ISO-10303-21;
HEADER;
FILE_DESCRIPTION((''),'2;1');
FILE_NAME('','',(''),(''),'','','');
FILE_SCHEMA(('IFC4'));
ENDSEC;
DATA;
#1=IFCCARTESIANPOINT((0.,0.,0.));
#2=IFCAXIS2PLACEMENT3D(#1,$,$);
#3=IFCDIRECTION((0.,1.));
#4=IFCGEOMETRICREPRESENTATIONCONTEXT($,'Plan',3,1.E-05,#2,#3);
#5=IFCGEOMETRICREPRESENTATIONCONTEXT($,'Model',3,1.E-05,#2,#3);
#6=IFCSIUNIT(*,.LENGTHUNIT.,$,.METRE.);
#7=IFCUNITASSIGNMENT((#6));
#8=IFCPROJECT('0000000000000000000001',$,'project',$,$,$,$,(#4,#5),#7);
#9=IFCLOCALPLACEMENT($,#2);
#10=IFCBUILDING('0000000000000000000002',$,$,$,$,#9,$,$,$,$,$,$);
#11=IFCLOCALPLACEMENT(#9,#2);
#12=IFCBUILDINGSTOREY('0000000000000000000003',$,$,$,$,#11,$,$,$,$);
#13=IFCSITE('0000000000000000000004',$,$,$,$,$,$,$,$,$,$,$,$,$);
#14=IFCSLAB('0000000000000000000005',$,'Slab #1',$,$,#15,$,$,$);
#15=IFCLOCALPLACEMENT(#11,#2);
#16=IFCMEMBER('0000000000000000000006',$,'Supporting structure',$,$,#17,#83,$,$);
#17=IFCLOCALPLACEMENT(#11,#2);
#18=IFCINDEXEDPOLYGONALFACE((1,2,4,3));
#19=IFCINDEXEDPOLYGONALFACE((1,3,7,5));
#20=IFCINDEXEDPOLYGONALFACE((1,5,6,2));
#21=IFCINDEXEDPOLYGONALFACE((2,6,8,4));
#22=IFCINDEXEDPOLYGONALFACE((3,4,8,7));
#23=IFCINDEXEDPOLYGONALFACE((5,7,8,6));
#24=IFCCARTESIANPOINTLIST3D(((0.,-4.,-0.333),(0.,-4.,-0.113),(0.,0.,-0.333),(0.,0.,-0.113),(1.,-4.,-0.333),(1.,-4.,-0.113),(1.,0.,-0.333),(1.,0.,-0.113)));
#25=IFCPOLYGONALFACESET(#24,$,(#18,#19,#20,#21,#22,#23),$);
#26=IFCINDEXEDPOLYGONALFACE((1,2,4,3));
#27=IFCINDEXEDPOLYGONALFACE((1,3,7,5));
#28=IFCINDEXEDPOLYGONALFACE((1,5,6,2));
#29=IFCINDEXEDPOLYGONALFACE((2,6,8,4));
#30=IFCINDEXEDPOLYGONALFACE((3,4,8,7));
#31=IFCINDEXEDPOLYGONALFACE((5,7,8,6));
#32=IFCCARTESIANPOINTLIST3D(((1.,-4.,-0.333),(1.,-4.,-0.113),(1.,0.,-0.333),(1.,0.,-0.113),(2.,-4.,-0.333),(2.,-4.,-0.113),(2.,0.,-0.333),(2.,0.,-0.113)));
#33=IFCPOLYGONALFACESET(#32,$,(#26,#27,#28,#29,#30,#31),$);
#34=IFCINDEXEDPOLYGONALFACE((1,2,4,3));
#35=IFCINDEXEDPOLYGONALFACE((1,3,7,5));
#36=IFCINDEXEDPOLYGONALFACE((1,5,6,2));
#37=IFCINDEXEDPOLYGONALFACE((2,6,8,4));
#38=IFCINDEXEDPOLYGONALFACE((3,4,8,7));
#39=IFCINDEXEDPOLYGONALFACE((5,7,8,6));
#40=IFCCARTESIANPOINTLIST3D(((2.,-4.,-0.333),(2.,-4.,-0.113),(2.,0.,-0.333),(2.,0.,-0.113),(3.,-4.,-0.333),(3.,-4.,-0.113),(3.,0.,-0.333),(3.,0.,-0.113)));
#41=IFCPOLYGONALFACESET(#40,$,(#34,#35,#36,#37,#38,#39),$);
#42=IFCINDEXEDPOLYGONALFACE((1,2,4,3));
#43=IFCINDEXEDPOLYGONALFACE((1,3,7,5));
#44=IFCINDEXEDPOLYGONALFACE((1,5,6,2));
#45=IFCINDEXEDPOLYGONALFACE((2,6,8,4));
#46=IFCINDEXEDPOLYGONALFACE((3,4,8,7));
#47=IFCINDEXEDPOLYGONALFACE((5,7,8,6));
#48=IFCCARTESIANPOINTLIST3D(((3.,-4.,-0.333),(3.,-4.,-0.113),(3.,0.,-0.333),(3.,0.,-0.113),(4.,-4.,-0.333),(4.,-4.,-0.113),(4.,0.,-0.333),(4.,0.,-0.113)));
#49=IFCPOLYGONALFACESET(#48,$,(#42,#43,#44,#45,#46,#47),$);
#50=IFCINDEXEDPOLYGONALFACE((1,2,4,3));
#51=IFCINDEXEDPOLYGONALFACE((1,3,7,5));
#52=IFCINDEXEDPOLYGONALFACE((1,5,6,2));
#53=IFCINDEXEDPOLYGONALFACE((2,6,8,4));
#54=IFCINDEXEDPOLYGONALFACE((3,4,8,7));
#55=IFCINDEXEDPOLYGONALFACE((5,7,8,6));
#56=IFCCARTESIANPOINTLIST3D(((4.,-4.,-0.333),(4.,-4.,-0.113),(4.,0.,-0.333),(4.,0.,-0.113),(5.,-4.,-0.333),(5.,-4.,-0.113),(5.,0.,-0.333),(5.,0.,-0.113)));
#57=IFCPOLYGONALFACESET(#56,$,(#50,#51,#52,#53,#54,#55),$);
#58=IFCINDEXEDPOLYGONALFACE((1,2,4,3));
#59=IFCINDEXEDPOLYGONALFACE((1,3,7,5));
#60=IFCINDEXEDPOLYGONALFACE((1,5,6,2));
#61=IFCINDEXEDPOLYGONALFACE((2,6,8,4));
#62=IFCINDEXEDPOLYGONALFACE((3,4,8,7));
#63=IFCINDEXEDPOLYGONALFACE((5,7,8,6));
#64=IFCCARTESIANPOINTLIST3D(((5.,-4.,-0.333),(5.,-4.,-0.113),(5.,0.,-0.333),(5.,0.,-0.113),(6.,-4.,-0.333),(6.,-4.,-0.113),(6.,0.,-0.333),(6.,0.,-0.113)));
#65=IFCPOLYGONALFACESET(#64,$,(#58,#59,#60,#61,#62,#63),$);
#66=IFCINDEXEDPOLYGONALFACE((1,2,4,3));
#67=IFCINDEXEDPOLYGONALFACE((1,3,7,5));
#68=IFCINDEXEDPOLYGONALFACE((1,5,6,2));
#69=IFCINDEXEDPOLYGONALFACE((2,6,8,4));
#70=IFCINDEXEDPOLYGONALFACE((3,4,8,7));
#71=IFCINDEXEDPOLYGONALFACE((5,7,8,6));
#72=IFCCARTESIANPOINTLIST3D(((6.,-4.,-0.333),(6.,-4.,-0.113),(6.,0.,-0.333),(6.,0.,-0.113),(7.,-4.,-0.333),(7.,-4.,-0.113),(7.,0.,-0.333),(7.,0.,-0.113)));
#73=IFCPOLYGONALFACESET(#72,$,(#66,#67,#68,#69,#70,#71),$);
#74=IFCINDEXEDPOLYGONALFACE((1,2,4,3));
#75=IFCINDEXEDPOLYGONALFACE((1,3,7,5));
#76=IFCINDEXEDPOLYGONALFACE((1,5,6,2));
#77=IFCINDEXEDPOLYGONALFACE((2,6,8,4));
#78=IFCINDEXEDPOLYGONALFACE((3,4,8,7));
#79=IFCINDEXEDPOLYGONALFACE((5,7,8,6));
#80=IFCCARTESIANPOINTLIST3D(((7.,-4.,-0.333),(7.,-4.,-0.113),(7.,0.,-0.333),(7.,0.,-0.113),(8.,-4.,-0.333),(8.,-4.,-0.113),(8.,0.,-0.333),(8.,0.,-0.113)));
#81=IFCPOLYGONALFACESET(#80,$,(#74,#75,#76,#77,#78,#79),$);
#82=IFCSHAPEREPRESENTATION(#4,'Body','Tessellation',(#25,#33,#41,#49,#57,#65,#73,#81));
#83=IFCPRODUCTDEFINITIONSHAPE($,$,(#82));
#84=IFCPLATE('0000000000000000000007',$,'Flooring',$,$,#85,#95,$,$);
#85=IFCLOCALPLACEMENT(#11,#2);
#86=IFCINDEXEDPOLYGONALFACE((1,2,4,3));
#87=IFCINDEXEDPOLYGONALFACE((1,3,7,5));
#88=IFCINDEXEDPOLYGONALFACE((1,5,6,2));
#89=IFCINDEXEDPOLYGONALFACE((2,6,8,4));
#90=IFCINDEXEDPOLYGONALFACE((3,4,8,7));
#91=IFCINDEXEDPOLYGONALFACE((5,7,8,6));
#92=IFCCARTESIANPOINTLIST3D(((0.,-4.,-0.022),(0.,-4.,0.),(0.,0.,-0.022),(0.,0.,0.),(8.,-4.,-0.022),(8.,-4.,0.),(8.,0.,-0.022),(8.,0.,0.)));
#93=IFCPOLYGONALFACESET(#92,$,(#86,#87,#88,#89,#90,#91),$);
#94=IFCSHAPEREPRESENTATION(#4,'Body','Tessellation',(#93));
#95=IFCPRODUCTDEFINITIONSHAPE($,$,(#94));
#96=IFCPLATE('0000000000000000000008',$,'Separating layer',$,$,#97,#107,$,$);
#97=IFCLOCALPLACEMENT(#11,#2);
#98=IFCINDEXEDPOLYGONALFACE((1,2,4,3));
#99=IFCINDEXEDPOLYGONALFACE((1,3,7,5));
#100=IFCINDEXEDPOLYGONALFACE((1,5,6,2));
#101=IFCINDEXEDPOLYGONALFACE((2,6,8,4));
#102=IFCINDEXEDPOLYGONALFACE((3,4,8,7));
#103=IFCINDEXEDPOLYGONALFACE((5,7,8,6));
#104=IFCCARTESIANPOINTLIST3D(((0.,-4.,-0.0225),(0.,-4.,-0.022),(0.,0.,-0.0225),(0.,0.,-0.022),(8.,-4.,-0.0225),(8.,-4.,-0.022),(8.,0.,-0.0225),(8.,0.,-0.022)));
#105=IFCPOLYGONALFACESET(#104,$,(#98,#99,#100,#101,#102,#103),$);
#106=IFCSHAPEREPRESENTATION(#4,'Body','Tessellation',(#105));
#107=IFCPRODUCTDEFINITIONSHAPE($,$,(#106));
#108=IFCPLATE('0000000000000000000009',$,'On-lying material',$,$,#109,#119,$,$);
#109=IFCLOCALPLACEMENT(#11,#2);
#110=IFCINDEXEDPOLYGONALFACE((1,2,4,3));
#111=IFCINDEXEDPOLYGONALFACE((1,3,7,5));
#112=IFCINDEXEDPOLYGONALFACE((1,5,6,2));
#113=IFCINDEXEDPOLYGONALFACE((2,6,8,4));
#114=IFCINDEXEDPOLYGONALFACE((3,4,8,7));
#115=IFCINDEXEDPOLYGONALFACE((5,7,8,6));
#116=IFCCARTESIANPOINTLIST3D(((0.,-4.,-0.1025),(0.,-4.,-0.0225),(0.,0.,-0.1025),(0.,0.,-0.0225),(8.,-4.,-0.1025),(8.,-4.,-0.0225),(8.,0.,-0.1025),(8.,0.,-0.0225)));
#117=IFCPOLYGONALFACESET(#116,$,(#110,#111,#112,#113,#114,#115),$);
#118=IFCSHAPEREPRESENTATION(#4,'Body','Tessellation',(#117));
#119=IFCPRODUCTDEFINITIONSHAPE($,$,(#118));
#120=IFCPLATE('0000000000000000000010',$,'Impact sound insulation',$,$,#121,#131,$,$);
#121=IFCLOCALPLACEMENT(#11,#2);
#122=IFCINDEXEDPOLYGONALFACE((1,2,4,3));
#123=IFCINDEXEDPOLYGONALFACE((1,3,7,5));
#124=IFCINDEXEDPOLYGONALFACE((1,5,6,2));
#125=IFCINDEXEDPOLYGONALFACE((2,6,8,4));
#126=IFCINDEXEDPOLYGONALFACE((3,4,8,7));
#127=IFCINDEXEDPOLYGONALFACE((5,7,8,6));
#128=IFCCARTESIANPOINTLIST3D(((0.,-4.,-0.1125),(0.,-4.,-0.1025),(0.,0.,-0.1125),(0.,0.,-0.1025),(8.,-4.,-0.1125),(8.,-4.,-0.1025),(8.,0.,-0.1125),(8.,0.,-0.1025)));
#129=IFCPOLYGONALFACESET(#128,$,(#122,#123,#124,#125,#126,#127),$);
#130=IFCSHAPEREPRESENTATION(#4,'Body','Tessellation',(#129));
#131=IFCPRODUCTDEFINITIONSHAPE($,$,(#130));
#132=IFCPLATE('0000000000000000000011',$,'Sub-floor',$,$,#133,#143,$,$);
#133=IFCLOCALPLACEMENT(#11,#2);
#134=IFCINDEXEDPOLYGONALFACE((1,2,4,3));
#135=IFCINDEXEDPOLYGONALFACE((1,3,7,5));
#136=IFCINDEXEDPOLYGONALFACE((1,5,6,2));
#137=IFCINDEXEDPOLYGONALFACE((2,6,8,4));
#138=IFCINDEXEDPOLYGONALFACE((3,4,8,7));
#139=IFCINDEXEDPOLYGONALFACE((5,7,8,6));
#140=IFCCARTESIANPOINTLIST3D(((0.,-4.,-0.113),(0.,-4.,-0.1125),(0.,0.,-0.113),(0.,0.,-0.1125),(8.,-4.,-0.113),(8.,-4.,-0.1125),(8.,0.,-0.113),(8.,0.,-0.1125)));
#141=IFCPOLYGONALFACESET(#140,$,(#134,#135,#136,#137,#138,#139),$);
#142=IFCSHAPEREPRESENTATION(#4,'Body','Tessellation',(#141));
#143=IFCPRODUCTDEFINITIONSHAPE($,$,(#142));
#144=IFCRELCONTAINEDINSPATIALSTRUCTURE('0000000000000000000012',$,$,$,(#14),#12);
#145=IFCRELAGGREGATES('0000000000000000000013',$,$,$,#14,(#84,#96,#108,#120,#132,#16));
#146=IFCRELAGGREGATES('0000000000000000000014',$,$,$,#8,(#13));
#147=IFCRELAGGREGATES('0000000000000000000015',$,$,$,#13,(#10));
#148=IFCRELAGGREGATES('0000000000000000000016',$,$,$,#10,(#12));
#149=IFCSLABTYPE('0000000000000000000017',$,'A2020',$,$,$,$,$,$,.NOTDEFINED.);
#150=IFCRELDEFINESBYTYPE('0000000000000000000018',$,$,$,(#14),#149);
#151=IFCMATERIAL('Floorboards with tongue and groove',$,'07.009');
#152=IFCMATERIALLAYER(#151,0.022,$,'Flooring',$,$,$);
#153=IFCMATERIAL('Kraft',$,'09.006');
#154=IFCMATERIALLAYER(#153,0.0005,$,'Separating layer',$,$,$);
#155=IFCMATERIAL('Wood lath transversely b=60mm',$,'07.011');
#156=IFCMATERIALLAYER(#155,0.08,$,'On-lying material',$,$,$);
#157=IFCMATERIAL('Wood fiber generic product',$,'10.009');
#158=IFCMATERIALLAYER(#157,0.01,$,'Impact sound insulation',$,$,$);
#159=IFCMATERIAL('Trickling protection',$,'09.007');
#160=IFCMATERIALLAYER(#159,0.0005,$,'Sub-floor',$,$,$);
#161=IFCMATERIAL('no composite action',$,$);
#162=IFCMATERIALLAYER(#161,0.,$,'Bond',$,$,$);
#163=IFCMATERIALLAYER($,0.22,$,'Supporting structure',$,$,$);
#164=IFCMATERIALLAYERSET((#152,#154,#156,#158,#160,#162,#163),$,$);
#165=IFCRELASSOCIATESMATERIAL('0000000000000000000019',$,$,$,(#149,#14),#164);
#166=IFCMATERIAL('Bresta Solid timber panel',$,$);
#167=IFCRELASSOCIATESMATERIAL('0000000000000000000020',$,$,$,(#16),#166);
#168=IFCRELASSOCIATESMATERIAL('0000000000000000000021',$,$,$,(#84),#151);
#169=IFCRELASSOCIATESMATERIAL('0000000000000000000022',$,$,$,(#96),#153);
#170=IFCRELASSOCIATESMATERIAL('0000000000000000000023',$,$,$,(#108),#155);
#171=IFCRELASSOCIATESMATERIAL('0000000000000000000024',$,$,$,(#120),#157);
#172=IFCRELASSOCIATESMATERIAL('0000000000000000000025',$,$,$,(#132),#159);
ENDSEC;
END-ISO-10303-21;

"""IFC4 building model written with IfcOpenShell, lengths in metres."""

from ifc_helpers import new_model, si_unit, direction, frame, frame_2d, origin, origin_with_axes, place, context, project, spatial, rectangle, extrude, material, layer, layer_set, type_object, element, aggregate, save


model = new_model("IFC4")

# Units and contexts
plan_context = context("Plan", 3, precision=1e-05, world=origin(), true_north=direction((0.0, 1.0)))
model_context = context("Model", 3, precision=1e-05, world=origin(), true_north=direction((0.0, 1.0)))
ifc_project = project(units=[si_unit("LENGTHUNIT", "METRE")], contexts=[plan_context, model_context])

# Site, building, storey
site = spatial("IfcSite", under=ifc_project)
building_placement = place(None, origin())
building = spatial("IfcBuilding", under=site, at=building_placement)
storey_placement = place(building_placement, origin())
storey = spatial("IfcBuildingStorey", under=building, at=storey_placement)

# Slab, member, plates
ifc_material_1 = material(Name="Floorboards with tongue and groove", Category="07.009")
ifc_layer_1 = layer(ifc_material_1, 0.022, Name="Flooring")
ifc_material_2 = material(Name="Kraft", Category="09.006")
ifc_layer_2 = layer(ifc_material_2, 0.0005, Name="Separating layer")
ifc_material_3 = material(Name="Wood lath transversely b=60mm", Category="07.011")
ifc_layer_3 = layer(ifc_material_3, 0.08, Name="On-lying material")
ifc_material_4 = material(Name="Wood fiber generic product", Category="10.009")
ifc_layer_4 = layer(ifc_material_4, 0.01, Name="Impact sound insulation")
ifc_material_5 = material(Name="Trickling protection", Category="09.007")
ifc_layer_5 = layer(ifc_material_5, 0.0005, Name="Sub-floor")
ifc_material_6 = material(Name="no composite action")
ifc_layer_6 = layer(ifc_material_6, 0.0, Name="Bond")
ifc_layer_7 = layer(None, 0.22, Name="Supporting structure")
ifc_layer_set = layer_set([ifc_layer_1, ifc_layer_2, ifc_layer_3, ifc_layer_4, ifc_layer_5, ifc_layer_6, ifc_layer_7])
slab_type = type_object("IfcSlabType", Name="A2020", PredefinedType="NOTDEFINED", material=ifc_layer_set)
slab_placement = place(None, frame((0.0, 0.0, 0.0), z_axis=(0.0, 0.0, -1.0), x_axis=(1.0, 0.0, 0.0)))
slab = element("IfcSlab", 1, at=slab_placement, inside=storey, type_object=slab_type, material=ifc_layer_set, Name="Slab #1")
ifc_material_7 = material(Name="Bresta Solid timber panel")
member_placement = place(slab_placement, origin())
member = element("IfcMember", 2, at=member_placement, material=ifc_material_7, Name="Supporting structure", context=plan_context, shape_type="SweptSolid", body=[
    extrude(rectangle(XDim=1.0, YDim=0.22, at=frame_2d((0.5, 0.11), x_axis=(1.0, 0.0))), frame((0.0, 4.0, 0.113), z_axis=(0.0, -1.0, 0.0), x_axis=(1.0, 0.0, 0.0)), (0.0, 0.0, 1.0), 4.0),
    extrude(rectangle(XDim=1.0, YDim=0.22, at=frame_2d((0.5, 0.11), x_axis=(1.0, 0.0))), frame((1.0, 4.0, 0.113), z_axis=(0.0, -1.0, 0.0), x_axis=(1.0, 0.0, 0.0)), (0.0, 0.0, 1.0), 4.0),
    extrude(rectangle(XDim=1.0, YDim=0.22, at=frame_2d((0.5, 0.11), x_axis=(1.0, 0.0))), frame((2.0, 4.0, 0.113), z_axis=(0.0, -1.0, 0.0), x_axis=(1.0, 0.0, 0.0)), (0.0, 0.0, 1.0), 4.0),
    extrude(rectangle(XDim=1.0, YDim=0.22, at=frame_2d((0.5, 0.11), x_axis=(1.0, 0.0))), frame((3.0, 4.0, 0.113), z_axis=(0.0, -1.0, 0.0), x_axis=(1.0, 0.0, 0.0)), (0.0, 0.0, 1.0), 4.0),
    extrude(rectangle(XDim=1.0, YDim=0.22, at=frame_2d((0.5, 0.11), x_axis=(1.0, 0.0))), frame((4.0, 4.0, 0.113), z_axis=(0.0, -1.0, 0.0), x_axis=(1.0, 0.0, 0.0)), (0.0, 0.0, 1.0), 4.0),
    extrude(rectangle(XDim=1.0, YDim=0.22, at=frame_2d((0.5, 0.11), x_axis=(1.0, 0.0))), frame((5.0, 4.0, 0.113), z_axis=(0.0, -1.0, 0.0), x_axis=(1.0, 0.0, 0.0)), (0.0, 0.0, 1.0), 4.0),
    extrude(rectangle(XDim=1.0, YDim=0.22, at=frame_2d((0.5, 0.11), x_axis=(1.0, 0.0))), frame((6.0, 4.0, 0.113), z_axis=(0.0, -1.0, 0.0), x_axis=(1.0, 0.0, 0.0)), (0.0, 0.0, 1.0), 4.0),
    extrude(rectangle(XDim=1.0, YDim=0.22, at=frame_2d((0.5, 0.11), x_axis=(1.0, 0.0))), frame((7.0, 4.0, 0.113), z_axis=(0.0, -1.0, 0.0), x_axis=(1.0, 0.0, 0.0)), (0.0, 0.0, 1.0), 4.0),
])
plate_1_placement = place(slab_placement, origin())
plate_1 = element("IfcPlate", 3, at=plate_1_placement, material=ifc_material_1, Name="Flooring", context=plan_context, shape_type="SweptSolid", body=[
    extrude(rectangle(XDim=8.0, YDim=4.0, at=frame_2d((4.0, 2.0), x_axis=(1.0, 0.0))), origin_with_axes(), (0.0, 0.0, 1.0), 0.022),
])
plate_2_placement = place(slab_placement, origin())
plate_2 = element("IfcPlate", 4, at=plate_2_placement, material=ifc_material_2, Name="Separating layer", context=plan_context, shape_type="SweptSolid", body=[
    extrude(rectangle(XDim=8.0, YDim=4.0, at=frame_2d((4.0, 2.0), x_axis=(1.0, 0.0))), frame((0.0, 0.0, 0.022), z_axis=(0.0, 0.0, 1.0), x_axis=(1.0, 0.0, 0.0)), (0.0, 0.0, 1.0), 0.0005),
])
plate_3_placement = place(slab_placement, origin())
plate_3 = element("IfcPlate", 5, at=plate_3_placement, material=ifc_material_3, Name="On-lying material", context=plan_context, shape_type="SweptSolid", body=[
    extrude(rectangle(XDim=8.0, YDim=4.0, at=frame_2d((4.0, 2.0), x_axis=(1.0, 0.0))), frame((0.0, 0.0, 0.0225), z_axis=(0.0, 0.0, 1.0), x_axis=(1.0, 0.0, 0.0)), (0.0, 0.0, 1.0), 0.08),
])
plate_4_placement = place(slab_placement, origin())
plate_4 = element("IfcPlate", 6, at=plate_4_placement, material=ifc_material_4, Name="Impact sound insulation", context=plan_context, shape_type="SweptSolid", body=[
    extrude(rectangle(XDim=8.0, YDim=4.0, at=frame_2d((4.0, 2.0), x_axis=(1.0, 0.0))), frame((0.0, 0.0, 0.1025), z_axis=(0.0, 0.0, 1.0), x_axis=(1.0, 0.0, 0.0)), (0.0, 0.0, 1.0), 0.01),
])
plate_5_placement = place(slab_placement, origin())
plate_5 = element("IfcPlate", 7, at=plate_5_placement, material=ifc_material_5, Name="Sub-floor", context=plan_context, shape_type="SweptSolid", body=[
    extrude(rectangle(XDim=8.0, YDim=4.0, at=frame_2d((4.0, 2.0), x_axis=(1.0, 0.0))), frame((0.0, 0.0, 0.1125), z_axis=(0.0, 0.0, 1.0), x_axis=(1.0, 0.0, 0.0)), (0.0, 0.0, 1.0), 0.0005),
])
aggregate(slab, [plate_1, plate_2, plate_3, plate_4, plate_5, member])

save(model, "model.ifc")
